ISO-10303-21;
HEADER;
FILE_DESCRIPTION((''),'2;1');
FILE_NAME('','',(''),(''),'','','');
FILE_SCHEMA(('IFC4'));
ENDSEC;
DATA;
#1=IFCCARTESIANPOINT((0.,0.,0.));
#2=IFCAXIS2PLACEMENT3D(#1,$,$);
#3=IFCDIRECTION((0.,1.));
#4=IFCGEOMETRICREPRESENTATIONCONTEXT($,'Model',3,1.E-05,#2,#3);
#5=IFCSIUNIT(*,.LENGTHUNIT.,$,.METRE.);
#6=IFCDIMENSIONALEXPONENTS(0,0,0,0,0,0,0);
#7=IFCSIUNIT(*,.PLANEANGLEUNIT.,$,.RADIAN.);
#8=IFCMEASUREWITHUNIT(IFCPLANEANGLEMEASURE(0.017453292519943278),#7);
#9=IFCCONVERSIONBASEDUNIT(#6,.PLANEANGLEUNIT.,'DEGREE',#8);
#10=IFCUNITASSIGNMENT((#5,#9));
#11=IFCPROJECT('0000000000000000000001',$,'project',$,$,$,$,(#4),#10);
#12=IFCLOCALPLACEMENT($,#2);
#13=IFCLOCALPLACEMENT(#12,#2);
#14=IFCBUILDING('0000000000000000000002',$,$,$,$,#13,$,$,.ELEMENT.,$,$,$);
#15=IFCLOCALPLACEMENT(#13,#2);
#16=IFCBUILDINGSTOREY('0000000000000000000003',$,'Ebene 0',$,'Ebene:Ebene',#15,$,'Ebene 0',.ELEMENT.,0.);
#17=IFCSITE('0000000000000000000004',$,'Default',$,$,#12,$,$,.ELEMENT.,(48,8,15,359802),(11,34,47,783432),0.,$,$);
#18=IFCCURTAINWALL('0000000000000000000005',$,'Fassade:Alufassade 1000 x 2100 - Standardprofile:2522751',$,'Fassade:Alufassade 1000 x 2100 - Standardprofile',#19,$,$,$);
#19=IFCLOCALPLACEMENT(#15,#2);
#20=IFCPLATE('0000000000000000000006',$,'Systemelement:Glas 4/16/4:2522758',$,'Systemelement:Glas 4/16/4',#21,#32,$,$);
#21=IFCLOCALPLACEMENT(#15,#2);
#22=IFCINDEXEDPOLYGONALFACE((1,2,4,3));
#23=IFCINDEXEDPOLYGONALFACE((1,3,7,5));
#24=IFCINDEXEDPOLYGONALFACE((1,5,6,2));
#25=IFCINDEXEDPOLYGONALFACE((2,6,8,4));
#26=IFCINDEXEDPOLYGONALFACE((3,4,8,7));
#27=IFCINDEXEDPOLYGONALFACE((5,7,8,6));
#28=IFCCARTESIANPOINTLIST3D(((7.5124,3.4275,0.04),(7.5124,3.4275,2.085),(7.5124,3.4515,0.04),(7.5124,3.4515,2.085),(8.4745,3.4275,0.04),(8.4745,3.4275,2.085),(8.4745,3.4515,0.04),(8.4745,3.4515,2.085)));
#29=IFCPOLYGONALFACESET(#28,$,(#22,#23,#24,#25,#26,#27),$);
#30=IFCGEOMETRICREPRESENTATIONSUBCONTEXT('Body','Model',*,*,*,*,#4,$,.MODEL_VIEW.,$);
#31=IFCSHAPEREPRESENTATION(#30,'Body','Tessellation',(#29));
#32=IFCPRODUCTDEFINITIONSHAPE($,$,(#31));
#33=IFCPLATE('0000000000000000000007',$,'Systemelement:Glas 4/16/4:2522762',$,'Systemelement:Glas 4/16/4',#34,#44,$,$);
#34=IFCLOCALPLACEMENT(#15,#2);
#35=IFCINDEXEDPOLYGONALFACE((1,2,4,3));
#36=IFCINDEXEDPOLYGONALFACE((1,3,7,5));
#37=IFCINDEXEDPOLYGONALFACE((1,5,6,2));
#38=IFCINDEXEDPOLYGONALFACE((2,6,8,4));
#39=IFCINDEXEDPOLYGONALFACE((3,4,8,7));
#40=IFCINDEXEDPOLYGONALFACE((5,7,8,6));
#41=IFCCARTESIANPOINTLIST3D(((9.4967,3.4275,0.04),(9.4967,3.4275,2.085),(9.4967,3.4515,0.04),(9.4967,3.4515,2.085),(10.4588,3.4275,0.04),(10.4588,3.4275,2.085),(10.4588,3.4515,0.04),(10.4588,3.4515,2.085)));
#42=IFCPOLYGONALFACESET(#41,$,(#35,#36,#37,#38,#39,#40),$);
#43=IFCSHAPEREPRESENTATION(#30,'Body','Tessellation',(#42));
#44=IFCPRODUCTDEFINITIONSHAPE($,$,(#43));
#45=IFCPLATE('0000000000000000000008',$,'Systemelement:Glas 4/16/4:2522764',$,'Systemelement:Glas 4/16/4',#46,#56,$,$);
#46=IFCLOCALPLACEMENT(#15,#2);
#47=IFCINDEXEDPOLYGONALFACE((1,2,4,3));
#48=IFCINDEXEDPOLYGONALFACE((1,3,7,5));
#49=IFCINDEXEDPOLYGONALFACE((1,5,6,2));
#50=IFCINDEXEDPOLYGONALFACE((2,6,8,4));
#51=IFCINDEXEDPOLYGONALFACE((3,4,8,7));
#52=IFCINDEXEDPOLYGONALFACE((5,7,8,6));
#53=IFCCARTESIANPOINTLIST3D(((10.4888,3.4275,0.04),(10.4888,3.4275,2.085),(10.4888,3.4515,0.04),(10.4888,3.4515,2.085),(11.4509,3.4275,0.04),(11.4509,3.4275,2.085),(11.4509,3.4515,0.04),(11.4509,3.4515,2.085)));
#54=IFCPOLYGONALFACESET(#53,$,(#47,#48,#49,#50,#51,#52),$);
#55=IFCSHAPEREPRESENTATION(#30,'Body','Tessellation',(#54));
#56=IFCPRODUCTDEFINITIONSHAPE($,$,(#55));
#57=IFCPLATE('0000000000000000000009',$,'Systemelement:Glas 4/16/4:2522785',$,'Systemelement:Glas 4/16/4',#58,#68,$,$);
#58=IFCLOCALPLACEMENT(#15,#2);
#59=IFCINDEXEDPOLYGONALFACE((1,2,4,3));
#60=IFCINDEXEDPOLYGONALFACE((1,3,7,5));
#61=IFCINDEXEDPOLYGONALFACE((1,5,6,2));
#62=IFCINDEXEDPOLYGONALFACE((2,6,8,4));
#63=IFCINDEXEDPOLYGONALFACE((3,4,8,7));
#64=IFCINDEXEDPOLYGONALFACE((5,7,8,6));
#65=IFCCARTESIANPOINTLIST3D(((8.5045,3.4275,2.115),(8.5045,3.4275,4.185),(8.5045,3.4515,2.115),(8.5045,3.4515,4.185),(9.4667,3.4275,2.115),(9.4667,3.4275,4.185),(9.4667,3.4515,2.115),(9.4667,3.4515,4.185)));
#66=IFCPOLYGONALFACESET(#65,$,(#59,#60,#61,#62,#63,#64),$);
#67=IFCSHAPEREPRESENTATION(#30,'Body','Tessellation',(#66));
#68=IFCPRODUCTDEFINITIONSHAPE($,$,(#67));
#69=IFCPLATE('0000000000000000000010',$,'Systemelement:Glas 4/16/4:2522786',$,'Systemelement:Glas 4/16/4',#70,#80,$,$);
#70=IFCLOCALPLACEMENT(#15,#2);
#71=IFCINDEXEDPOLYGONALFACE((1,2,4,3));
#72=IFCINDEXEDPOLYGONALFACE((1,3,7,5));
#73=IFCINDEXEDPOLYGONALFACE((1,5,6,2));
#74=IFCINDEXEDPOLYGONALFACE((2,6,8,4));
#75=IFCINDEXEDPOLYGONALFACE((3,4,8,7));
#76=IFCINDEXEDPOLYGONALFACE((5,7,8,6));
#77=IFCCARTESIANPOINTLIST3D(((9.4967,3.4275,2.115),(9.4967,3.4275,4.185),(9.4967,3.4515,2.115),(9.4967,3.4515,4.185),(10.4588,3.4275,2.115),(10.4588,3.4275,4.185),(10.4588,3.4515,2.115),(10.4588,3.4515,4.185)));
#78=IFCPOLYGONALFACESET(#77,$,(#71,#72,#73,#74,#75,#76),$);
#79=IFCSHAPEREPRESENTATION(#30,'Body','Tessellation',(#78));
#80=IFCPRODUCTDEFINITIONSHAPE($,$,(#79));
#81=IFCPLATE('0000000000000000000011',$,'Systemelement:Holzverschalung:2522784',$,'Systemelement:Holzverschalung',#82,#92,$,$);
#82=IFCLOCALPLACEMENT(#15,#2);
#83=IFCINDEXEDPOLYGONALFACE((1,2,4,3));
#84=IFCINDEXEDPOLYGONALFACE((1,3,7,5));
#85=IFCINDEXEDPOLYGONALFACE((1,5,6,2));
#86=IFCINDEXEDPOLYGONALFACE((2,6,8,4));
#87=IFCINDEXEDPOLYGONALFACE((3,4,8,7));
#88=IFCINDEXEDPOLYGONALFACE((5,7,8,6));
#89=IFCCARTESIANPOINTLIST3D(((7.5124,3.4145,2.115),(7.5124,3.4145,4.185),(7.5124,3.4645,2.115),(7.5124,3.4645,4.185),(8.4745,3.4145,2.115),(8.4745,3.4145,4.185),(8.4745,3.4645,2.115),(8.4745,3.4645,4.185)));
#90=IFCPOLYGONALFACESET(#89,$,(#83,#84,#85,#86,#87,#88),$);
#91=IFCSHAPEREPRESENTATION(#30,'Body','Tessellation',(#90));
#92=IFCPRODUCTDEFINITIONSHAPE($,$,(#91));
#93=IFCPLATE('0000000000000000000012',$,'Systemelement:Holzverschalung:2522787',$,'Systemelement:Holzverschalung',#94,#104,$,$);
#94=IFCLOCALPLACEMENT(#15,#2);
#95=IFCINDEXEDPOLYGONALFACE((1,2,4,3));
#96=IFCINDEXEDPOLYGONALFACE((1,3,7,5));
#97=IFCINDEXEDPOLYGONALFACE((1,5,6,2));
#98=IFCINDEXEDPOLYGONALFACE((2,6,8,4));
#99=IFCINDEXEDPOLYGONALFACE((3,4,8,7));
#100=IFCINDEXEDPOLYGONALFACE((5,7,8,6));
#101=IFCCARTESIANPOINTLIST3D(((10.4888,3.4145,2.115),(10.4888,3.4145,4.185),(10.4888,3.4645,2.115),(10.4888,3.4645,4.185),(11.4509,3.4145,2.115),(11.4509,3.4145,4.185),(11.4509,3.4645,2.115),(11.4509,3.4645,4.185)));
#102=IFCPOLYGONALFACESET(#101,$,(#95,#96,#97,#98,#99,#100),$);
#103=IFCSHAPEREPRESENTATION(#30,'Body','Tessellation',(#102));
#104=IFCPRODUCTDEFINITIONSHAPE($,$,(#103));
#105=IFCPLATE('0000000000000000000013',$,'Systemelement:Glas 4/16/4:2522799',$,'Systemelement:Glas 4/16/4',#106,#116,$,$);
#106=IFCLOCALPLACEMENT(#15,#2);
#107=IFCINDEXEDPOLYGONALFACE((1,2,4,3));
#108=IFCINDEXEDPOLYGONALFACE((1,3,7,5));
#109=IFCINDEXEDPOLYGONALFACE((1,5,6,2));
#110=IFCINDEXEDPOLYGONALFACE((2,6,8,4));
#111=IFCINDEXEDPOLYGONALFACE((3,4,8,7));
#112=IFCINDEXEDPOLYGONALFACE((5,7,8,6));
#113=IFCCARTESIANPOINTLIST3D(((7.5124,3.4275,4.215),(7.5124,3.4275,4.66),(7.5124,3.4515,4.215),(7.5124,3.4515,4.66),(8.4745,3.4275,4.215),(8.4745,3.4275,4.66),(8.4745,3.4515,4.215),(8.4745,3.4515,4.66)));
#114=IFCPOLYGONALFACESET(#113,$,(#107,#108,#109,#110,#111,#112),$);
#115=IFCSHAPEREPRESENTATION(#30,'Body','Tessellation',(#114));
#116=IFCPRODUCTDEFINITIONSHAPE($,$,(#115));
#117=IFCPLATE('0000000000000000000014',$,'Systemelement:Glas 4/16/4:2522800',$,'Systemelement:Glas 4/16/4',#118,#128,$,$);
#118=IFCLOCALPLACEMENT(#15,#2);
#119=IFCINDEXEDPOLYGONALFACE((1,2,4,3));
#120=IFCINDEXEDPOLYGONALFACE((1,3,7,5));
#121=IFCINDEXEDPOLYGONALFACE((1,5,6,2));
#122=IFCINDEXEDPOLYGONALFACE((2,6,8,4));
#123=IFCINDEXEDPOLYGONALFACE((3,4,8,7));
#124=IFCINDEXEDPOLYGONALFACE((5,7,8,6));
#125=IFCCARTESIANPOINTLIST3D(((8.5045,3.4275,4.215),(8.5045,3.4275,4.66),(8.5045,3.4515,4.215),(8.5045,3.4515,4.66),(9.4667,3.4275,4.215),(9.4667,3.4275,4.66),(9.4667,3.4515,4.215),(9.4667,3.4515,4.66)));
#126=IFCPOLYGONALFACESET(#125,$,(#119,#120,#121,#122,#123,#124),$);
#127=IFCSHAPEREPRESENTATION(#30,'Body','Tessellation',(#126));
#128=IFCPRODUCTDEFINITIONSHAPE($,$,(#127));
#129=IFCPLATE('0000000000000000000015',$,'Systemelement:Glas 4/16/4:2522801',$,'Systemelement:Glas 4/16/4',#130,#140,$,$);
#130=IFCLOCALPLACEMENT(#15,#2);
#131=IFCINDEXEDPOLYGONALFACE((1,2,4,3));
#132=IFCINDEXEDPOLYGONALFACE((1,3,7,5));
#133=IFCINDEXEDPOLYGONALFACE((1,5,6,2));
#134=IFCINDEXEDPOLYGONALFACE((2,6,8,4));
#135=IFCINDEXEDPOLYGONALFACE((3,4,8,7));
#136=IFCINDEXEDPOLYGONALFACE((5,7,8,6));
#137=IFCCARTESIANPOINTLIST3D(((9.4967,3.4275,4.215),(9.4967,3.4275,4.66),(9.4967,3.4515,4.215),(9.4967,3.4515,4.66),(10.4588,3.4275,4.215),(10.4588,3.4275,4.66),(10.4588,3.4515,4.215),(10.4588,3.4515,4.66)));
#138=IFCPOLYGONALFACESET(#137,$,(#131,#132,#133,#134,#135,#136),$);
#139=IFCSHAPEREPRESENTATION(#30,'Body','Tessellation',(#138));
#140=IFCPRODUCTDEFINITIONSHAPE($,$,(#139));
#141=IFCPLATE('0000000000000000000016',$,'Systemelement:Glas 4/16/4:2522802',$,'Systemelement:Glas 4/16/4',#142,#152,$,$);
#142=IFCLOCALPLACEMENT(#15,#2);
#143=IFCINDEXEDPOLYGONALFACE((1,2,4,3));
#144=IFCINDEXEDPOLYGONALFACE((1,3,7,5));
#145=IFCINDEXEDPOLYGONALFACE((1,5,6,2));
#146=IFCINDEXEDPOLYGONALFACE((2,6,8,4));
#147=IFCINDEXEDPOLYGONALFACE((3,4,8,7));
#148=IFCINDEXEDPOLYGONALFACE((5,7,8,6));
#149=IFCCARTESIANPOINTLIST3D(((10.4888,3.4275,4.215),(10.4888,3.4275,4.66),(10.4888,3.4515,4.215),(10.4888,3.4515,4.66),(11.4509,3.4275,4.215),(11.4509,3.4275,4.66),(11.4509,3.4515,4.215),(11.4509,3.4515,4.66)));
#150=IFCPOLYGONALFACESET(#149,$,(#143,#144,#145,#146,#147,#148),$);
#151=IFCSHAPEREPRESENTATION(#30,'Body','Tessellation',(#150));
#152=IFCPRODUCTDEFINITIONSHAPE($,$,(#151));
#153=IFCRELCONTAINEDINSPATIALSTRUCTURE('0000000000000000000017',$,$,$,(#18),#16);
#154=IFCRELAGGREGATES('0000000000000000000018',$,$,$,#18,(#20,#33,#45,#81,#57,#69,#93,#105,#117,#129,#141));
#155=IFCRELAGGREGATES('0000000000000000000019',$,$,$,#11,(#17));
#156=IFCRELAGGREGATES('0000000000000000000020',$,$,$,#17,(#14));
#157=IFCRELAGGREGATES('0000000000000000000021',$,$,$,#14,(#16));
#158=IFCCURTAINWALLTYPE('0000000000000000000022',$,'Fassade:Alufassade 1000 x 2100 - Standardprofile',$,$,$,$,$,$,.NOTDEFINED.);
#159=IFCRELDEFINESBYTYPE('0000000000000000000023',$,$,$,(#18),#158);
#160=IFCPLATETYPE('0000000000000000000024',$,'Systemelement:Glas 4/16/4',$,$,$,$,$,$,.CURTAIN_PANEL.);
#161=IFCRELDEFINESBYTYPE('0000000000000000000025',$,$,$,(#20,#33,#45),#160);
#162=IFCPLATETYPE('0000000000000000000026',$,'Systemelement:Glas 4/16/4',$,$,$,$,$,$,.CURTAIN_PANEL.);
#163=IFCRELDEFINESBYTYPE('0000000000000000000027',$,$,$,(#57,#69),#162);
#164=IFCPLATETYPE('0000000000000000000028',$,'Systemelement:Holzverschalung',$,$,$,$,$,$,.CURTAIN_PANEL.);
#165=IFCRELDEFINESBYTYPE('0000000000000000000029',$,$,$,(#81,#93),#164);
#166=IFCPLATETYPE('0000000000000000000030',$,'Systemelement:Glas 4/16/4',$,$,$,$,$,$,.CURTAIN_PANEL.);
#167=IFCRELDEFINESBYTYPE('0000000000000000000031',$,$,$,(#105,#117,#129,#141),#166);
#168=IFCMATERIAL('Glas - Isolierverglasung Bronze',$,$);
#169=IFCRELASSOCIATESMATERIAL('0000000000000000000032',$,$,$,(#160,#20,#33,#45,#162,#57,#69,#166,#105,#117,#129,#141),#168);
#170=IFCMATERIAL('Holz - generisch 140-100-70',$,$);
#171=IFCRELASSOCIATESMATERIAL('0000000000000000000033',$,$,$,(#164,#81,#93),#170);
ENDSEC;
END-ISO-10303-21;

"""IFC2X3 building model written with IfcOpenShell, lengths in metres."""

from ifc_helpers import new_model, entity, si_unit, converted_unit, direction, frame, origin, origin_2d_with_axis, place, context, subcontext, project, spatial, rectangle, extrude, source, transform, mapped, material, type_object, type_shapes, element, aggregate, save


model = new_model("IFC2X3")

# Units and contexts
model_context = context("Model", 3, precision=1e-05, world=origin(), true_north=direction((0.0, 1.0)))
body_context = subcontext(model_context, "Body", "Model", "MODEL_VIEW")
ifc_project = project(units=[si_unit("LENGTHUNIT", "METRE"), converted_unit("PLANEANGLEUNIT", "DEGREE", entity("IfcPlaneAngleMeasure", 0.017453292519943278), si_unit("PLANEANGLEUNIT", "RADIAN"), dimensions=[0, 0, 0, 0, 0, 0, 0])], contexts=[model_context])

# Site, building, storey
site_placement = place(None, origin())
site = spatial("IfcSite", under=ifc_project, at=site_placement, Name="Default", CompositionType="ELEMENT", RefLatitude=(48, 8, 15, 359802), RefLongitude=(11, 34, 47, 783432), RefElevation=0.0)
building_placement = place(site_placement, origin())
building = spatial("IfcBuilding", under=site, at=building_placement, CompositionType="ELEMENT")
storey_placement = place(building_placement, origin())
storey = spatial("IfcBuildingStorey", under=building, at=storey_placement, Name="Ebene 0", ObjectType="Ebene:Ebene", LongName="Ebene 0", CompositionType="ELEMENT", Elevation=0.0)

# Curtain wall, plates
curtain_wall_type = type_object("IfcCurtainWallType", Name="Fassade:Alufassade 1000 x 2100 - Standardprofile", PredefinedType="NOTDEFINED")
curtain_wall_placement = place(storey_placement, origin())
curtain_wall = element("IfcCurtainWall", 1, at=curtain_wall_placement, inside=storey, type_object=curtain_wall_type, Name="Fassade:Alufassade 1000 x 2100 - Standardprofile:2522751", ObjectType="Fassade:Alufassade 1000 x 2100 - Standardprofile")
ifc_material_1 = material(Name="Glas - Isolierverglasung Bronze")
plate_type_1 = type_object("IfcPlateType", Name="Systemelement:Glas 4/16/4", PredefinedType="CURTAIN_PANEL", material=ifc_material_1)
shared_shape_1 = source(origin(), body_context, "Body", "SweptSolid", [
    extrude(rectangle(XDim=0.024, YDim=0.9621, at=origin_2d_with_axis()), frame((0.0, 0.0, 0.0), z_axis=(0.0, 0.0, 1.0), x_axis=(0.0, 1.0, 0.0)), (0.0, 0.0, 1.0), 2.045),
])
type_shapes(plate_type_1, [shared_shape_1])
plate_1_placement = place(curtain_wall_placement, frame((7.9934, 3.4395, 0.04)))
plate_1 = element("IfcPlate", 2, at=plate_1_placement, type_object=plate_type_1, material=ifc_material_1, Name="Systemelement:Glas 4/16/4:2522758", ObjectType="Systemelement:Glas 4/16/4", context=body_context, shape_type="MappedRepresentation", body=[
    mapped(shared_shape_1, transform((0.0, 0.0, 0.0), scale=1.0)),
])
plate_2_placement = place(curtain_wall_placement, frame((9.9777, 3.4395, 0.04)))
plate_2 = element("IfcPlate", 3, at=plate_2_placement, type_object=plate_type_1, material=ifc_material_1, Name="Systemelement:Glas 4/16/4:2522762", ObjectType="Systemelement:Glas 4/16/4", context=body_context, shape_type="MappedRepresentation", body=[
    mapped(shared_shape_1, transform((0.0, 0.0, 0.0), scale=1.0)),
])
plate_3_placement = place(curtain_wall_placement, frame((10.9699, 3.4395, 0.04)))
plate_3 = element("IfcPlate", 4, at=plate_3_placement, type_object=plate_type_1, material=ifc_material_1, Name="Systemelement:Glas 4/16/4:2522764", ObjectType="Systemelement:Glas 4/16/4", context=body_context, shape_type="MappedRepresentation", body=[
    mapped(shared_shape_1, transform((0.0, 0.0, 0.0), scale=1.0)),
])
plate_type_2 = type_object("IfcPlateType", Name="Systemelement:Glas 4/16/4", PredefinedType="CURTAIN_PANEL", material=ifc_material_1)
shared_shape_2 = source(origin(), body_context, "Body", "SweptSolid", [
    extrude(rectangle(XDim=0.024, YDim=0.9621, at=origin_2d_with_axis()), frame((0.0, 0.0, 0.0), z_axis=(0.0, 0.0, 1.0), x_axis=(0.0, 1.0, 0.0)), (0.0, 0.0, 1.0), 2.07),
])
type_shapes(plate_type_2, [shared_shape_2])
plate_4_placement = place(curtain_wall_placement, frame((8.9856, 3.4395, 2.115)))
plate_4 = element("IfcPlate", 5, at=plate_4_placement, type_object=plate_type_2, material=ifc_material_1, Name="Systemelement:Glas 4/16/4:2522785", ObjectType="Systemelement:Glas 4/16/4", context=body_context, shape_type="MappedRepresentation", body=[
    mapped(shared_shape_2, transform((0.0, 0.0, 0.0), scale=1.0)),
])
plate_5_placement = place(curtain_wall_placement, frame((9.9777, 3.4395, 2.115)))
plate_5 = element("IfcPlate", 6, at=plate_5_placement, type_object=plate_type_2, material=ifc_material_1, Name="Systemelement:Glas 4/16/4:2522786", ObjectType="Systemelement:Glas 4/16/4", context=body_context, shape_type="MappedRepresentation", body=[
    mapped(shared_shape_2, transform((0.0, 0.0, 0.0), scale=1.0)),
])
ifc_material_2 = material(Name="Holz - generisch 140-100-70")
plate_type_3 = type_object("IfcPlateType", Name="Systemelement:Holzverschalung", PredefinedType="CURTAIN_PANEL", material=ifc_material_2)
shared_shape_3 = source(origin(), body_context, "Body", "SweptSolid", [
    extrude(rectangle(XDim=0.05, YDim=0.9621, at=origin_2d_with_axis()), frame((0.0, 0.0, 0.0), z_axis=(0.0, 0.0, 1.0), x_axis=(0.0, 1.0, 0.0)), (0.0, 0.0, 1.0), 2.07),
])
type_shapes(plate_type_3, [shared_shape_3])
plate_6_placement = place(curtain_wall_placement, frame((7.9934, 3.4395, 2.115)))
plate_6 = element("IfcPlate", 7, at=plate_6_placement, type_object=plate_type_3, material=ifc_material_2, Name="Systemelement:Holzverschalung:2522784", ObjectType="Systemelement:Holzverschalung", context=body_context, shape_type="MappedRepresentation", body=[
    mapped(shared_shape_3, transform((0.0, 0.0, 0.0), scale=1.0)),
])
plate_7_placement = place(curtain_wall_placement, frame((10.9699, 3.4395, 2.115)))
plate_7 = element("IfcPlate", 8, at=plate_7_placement, type_object=plate_type_3, material=ifc_material_2, Name="Systemelement:Holzverschalung:2522787", ObjectType="Systemelement:Holzverschalung", context=body_context, shape_type="MappedRepresentation", body=[
    mapped(shared_shape_3, transform((0.0, 0.0, 0.0), scale=1.0)),
])
plate_type_4 = type_object("IfcPlateType", Name="Systemelement:Glas 4/16/4", PredefinedType="CURTAIN_PANEL", material=ifc_material_1)
shared_shape_4 = source(origin(), body_context, "Body", "SweptSolid", [
    extrude(rectangle(XDim=0.024, YDim=0.9621, at=origin_2d_with_axis()), frame((0.0, 0.0, 0.0), z_axis=(0.0, 0.0, 1.0), x_axis=(0.0, 1.0, 0.0)), (0.0, 0.0, 1.0), 0.445),
])
type_shapes(plate_type_4, [shared_shape_4])
plate_8_placement = place(curtain_wall_placement, frame((7.9934, 3.4395, 4.215)))
plate_8 = element("IfcPlate", 9, at=plate_8_placement, type_object=plate_type_4, material=ifc_material_1, Name="Systemelement:Glas 4/16/4:2522799", ObjectType="Systemelement:Glas 4/16/4", context=body_context, shape_type="MappedRepresentation", body=[
    mapped(shared_shape_4, transform((0.0, 0.0, 0.0), scale=1.0)),
])
plate_9_placement = place(curtain_wall_placement, frame((8.9856, 3.4395, 4.215)))
plate_9 = element("IfcPlate", 10, at=plate_9_placement, type_object=plate_type_4, material=ifc_material_1, Name="Systemelement:Glas 4/16/4:2522800", ObjectType="Systemelement:Glas 4/16/4", context=body_context, shape_type="MappedRepresentation", body=[
    mapped(shared_shape_4, transform((0.0, 0.0, 0.0), scale=1.0)),
])
plate_10_placement = place(curtain_wall_placement, frame((9.9777, 3.4395, 4.215)))
plate_10 = element("IfcPlate", 11, at=plate_10_placement, type_object=plate_type_4, material=ifc_material_1, Name="Systemelement:Glas 4/16/4:2522801", ObjectType="Systemelement:Glas 4/16/4", context=body_context, shape_type="MappedRepresentation", body=[
    mapped(shared_shape_4, transform((0.0, 0.0, 0.0), scale=1.0)),
])
plate_11_placement = place(curtain_wall_placement, frame((10.9699, 3.4395, 4.215)))
plate_11 = element("IfcPlate", 12, at=plate_11_placement, type_object=plate_type_4, material=ifc_material_1, Name="Systemelement:Glas 4/16/4:2522802", ObjectType="Systemelement:Glas 4/16/4", context=body_context, shape_type="MappedRepresentation", body=[
    mapped(shared_shape_4, transform((0.0, 0.0, 0.0), scale=1.0)),
])
aggregate(curtain_wall, [plate_1, plate_2, plate_3, plate_6, plate_4, plate_5, plate_7, plate_8, plate_9, plate_10, plate_11])

save(model, "model.ifc")
